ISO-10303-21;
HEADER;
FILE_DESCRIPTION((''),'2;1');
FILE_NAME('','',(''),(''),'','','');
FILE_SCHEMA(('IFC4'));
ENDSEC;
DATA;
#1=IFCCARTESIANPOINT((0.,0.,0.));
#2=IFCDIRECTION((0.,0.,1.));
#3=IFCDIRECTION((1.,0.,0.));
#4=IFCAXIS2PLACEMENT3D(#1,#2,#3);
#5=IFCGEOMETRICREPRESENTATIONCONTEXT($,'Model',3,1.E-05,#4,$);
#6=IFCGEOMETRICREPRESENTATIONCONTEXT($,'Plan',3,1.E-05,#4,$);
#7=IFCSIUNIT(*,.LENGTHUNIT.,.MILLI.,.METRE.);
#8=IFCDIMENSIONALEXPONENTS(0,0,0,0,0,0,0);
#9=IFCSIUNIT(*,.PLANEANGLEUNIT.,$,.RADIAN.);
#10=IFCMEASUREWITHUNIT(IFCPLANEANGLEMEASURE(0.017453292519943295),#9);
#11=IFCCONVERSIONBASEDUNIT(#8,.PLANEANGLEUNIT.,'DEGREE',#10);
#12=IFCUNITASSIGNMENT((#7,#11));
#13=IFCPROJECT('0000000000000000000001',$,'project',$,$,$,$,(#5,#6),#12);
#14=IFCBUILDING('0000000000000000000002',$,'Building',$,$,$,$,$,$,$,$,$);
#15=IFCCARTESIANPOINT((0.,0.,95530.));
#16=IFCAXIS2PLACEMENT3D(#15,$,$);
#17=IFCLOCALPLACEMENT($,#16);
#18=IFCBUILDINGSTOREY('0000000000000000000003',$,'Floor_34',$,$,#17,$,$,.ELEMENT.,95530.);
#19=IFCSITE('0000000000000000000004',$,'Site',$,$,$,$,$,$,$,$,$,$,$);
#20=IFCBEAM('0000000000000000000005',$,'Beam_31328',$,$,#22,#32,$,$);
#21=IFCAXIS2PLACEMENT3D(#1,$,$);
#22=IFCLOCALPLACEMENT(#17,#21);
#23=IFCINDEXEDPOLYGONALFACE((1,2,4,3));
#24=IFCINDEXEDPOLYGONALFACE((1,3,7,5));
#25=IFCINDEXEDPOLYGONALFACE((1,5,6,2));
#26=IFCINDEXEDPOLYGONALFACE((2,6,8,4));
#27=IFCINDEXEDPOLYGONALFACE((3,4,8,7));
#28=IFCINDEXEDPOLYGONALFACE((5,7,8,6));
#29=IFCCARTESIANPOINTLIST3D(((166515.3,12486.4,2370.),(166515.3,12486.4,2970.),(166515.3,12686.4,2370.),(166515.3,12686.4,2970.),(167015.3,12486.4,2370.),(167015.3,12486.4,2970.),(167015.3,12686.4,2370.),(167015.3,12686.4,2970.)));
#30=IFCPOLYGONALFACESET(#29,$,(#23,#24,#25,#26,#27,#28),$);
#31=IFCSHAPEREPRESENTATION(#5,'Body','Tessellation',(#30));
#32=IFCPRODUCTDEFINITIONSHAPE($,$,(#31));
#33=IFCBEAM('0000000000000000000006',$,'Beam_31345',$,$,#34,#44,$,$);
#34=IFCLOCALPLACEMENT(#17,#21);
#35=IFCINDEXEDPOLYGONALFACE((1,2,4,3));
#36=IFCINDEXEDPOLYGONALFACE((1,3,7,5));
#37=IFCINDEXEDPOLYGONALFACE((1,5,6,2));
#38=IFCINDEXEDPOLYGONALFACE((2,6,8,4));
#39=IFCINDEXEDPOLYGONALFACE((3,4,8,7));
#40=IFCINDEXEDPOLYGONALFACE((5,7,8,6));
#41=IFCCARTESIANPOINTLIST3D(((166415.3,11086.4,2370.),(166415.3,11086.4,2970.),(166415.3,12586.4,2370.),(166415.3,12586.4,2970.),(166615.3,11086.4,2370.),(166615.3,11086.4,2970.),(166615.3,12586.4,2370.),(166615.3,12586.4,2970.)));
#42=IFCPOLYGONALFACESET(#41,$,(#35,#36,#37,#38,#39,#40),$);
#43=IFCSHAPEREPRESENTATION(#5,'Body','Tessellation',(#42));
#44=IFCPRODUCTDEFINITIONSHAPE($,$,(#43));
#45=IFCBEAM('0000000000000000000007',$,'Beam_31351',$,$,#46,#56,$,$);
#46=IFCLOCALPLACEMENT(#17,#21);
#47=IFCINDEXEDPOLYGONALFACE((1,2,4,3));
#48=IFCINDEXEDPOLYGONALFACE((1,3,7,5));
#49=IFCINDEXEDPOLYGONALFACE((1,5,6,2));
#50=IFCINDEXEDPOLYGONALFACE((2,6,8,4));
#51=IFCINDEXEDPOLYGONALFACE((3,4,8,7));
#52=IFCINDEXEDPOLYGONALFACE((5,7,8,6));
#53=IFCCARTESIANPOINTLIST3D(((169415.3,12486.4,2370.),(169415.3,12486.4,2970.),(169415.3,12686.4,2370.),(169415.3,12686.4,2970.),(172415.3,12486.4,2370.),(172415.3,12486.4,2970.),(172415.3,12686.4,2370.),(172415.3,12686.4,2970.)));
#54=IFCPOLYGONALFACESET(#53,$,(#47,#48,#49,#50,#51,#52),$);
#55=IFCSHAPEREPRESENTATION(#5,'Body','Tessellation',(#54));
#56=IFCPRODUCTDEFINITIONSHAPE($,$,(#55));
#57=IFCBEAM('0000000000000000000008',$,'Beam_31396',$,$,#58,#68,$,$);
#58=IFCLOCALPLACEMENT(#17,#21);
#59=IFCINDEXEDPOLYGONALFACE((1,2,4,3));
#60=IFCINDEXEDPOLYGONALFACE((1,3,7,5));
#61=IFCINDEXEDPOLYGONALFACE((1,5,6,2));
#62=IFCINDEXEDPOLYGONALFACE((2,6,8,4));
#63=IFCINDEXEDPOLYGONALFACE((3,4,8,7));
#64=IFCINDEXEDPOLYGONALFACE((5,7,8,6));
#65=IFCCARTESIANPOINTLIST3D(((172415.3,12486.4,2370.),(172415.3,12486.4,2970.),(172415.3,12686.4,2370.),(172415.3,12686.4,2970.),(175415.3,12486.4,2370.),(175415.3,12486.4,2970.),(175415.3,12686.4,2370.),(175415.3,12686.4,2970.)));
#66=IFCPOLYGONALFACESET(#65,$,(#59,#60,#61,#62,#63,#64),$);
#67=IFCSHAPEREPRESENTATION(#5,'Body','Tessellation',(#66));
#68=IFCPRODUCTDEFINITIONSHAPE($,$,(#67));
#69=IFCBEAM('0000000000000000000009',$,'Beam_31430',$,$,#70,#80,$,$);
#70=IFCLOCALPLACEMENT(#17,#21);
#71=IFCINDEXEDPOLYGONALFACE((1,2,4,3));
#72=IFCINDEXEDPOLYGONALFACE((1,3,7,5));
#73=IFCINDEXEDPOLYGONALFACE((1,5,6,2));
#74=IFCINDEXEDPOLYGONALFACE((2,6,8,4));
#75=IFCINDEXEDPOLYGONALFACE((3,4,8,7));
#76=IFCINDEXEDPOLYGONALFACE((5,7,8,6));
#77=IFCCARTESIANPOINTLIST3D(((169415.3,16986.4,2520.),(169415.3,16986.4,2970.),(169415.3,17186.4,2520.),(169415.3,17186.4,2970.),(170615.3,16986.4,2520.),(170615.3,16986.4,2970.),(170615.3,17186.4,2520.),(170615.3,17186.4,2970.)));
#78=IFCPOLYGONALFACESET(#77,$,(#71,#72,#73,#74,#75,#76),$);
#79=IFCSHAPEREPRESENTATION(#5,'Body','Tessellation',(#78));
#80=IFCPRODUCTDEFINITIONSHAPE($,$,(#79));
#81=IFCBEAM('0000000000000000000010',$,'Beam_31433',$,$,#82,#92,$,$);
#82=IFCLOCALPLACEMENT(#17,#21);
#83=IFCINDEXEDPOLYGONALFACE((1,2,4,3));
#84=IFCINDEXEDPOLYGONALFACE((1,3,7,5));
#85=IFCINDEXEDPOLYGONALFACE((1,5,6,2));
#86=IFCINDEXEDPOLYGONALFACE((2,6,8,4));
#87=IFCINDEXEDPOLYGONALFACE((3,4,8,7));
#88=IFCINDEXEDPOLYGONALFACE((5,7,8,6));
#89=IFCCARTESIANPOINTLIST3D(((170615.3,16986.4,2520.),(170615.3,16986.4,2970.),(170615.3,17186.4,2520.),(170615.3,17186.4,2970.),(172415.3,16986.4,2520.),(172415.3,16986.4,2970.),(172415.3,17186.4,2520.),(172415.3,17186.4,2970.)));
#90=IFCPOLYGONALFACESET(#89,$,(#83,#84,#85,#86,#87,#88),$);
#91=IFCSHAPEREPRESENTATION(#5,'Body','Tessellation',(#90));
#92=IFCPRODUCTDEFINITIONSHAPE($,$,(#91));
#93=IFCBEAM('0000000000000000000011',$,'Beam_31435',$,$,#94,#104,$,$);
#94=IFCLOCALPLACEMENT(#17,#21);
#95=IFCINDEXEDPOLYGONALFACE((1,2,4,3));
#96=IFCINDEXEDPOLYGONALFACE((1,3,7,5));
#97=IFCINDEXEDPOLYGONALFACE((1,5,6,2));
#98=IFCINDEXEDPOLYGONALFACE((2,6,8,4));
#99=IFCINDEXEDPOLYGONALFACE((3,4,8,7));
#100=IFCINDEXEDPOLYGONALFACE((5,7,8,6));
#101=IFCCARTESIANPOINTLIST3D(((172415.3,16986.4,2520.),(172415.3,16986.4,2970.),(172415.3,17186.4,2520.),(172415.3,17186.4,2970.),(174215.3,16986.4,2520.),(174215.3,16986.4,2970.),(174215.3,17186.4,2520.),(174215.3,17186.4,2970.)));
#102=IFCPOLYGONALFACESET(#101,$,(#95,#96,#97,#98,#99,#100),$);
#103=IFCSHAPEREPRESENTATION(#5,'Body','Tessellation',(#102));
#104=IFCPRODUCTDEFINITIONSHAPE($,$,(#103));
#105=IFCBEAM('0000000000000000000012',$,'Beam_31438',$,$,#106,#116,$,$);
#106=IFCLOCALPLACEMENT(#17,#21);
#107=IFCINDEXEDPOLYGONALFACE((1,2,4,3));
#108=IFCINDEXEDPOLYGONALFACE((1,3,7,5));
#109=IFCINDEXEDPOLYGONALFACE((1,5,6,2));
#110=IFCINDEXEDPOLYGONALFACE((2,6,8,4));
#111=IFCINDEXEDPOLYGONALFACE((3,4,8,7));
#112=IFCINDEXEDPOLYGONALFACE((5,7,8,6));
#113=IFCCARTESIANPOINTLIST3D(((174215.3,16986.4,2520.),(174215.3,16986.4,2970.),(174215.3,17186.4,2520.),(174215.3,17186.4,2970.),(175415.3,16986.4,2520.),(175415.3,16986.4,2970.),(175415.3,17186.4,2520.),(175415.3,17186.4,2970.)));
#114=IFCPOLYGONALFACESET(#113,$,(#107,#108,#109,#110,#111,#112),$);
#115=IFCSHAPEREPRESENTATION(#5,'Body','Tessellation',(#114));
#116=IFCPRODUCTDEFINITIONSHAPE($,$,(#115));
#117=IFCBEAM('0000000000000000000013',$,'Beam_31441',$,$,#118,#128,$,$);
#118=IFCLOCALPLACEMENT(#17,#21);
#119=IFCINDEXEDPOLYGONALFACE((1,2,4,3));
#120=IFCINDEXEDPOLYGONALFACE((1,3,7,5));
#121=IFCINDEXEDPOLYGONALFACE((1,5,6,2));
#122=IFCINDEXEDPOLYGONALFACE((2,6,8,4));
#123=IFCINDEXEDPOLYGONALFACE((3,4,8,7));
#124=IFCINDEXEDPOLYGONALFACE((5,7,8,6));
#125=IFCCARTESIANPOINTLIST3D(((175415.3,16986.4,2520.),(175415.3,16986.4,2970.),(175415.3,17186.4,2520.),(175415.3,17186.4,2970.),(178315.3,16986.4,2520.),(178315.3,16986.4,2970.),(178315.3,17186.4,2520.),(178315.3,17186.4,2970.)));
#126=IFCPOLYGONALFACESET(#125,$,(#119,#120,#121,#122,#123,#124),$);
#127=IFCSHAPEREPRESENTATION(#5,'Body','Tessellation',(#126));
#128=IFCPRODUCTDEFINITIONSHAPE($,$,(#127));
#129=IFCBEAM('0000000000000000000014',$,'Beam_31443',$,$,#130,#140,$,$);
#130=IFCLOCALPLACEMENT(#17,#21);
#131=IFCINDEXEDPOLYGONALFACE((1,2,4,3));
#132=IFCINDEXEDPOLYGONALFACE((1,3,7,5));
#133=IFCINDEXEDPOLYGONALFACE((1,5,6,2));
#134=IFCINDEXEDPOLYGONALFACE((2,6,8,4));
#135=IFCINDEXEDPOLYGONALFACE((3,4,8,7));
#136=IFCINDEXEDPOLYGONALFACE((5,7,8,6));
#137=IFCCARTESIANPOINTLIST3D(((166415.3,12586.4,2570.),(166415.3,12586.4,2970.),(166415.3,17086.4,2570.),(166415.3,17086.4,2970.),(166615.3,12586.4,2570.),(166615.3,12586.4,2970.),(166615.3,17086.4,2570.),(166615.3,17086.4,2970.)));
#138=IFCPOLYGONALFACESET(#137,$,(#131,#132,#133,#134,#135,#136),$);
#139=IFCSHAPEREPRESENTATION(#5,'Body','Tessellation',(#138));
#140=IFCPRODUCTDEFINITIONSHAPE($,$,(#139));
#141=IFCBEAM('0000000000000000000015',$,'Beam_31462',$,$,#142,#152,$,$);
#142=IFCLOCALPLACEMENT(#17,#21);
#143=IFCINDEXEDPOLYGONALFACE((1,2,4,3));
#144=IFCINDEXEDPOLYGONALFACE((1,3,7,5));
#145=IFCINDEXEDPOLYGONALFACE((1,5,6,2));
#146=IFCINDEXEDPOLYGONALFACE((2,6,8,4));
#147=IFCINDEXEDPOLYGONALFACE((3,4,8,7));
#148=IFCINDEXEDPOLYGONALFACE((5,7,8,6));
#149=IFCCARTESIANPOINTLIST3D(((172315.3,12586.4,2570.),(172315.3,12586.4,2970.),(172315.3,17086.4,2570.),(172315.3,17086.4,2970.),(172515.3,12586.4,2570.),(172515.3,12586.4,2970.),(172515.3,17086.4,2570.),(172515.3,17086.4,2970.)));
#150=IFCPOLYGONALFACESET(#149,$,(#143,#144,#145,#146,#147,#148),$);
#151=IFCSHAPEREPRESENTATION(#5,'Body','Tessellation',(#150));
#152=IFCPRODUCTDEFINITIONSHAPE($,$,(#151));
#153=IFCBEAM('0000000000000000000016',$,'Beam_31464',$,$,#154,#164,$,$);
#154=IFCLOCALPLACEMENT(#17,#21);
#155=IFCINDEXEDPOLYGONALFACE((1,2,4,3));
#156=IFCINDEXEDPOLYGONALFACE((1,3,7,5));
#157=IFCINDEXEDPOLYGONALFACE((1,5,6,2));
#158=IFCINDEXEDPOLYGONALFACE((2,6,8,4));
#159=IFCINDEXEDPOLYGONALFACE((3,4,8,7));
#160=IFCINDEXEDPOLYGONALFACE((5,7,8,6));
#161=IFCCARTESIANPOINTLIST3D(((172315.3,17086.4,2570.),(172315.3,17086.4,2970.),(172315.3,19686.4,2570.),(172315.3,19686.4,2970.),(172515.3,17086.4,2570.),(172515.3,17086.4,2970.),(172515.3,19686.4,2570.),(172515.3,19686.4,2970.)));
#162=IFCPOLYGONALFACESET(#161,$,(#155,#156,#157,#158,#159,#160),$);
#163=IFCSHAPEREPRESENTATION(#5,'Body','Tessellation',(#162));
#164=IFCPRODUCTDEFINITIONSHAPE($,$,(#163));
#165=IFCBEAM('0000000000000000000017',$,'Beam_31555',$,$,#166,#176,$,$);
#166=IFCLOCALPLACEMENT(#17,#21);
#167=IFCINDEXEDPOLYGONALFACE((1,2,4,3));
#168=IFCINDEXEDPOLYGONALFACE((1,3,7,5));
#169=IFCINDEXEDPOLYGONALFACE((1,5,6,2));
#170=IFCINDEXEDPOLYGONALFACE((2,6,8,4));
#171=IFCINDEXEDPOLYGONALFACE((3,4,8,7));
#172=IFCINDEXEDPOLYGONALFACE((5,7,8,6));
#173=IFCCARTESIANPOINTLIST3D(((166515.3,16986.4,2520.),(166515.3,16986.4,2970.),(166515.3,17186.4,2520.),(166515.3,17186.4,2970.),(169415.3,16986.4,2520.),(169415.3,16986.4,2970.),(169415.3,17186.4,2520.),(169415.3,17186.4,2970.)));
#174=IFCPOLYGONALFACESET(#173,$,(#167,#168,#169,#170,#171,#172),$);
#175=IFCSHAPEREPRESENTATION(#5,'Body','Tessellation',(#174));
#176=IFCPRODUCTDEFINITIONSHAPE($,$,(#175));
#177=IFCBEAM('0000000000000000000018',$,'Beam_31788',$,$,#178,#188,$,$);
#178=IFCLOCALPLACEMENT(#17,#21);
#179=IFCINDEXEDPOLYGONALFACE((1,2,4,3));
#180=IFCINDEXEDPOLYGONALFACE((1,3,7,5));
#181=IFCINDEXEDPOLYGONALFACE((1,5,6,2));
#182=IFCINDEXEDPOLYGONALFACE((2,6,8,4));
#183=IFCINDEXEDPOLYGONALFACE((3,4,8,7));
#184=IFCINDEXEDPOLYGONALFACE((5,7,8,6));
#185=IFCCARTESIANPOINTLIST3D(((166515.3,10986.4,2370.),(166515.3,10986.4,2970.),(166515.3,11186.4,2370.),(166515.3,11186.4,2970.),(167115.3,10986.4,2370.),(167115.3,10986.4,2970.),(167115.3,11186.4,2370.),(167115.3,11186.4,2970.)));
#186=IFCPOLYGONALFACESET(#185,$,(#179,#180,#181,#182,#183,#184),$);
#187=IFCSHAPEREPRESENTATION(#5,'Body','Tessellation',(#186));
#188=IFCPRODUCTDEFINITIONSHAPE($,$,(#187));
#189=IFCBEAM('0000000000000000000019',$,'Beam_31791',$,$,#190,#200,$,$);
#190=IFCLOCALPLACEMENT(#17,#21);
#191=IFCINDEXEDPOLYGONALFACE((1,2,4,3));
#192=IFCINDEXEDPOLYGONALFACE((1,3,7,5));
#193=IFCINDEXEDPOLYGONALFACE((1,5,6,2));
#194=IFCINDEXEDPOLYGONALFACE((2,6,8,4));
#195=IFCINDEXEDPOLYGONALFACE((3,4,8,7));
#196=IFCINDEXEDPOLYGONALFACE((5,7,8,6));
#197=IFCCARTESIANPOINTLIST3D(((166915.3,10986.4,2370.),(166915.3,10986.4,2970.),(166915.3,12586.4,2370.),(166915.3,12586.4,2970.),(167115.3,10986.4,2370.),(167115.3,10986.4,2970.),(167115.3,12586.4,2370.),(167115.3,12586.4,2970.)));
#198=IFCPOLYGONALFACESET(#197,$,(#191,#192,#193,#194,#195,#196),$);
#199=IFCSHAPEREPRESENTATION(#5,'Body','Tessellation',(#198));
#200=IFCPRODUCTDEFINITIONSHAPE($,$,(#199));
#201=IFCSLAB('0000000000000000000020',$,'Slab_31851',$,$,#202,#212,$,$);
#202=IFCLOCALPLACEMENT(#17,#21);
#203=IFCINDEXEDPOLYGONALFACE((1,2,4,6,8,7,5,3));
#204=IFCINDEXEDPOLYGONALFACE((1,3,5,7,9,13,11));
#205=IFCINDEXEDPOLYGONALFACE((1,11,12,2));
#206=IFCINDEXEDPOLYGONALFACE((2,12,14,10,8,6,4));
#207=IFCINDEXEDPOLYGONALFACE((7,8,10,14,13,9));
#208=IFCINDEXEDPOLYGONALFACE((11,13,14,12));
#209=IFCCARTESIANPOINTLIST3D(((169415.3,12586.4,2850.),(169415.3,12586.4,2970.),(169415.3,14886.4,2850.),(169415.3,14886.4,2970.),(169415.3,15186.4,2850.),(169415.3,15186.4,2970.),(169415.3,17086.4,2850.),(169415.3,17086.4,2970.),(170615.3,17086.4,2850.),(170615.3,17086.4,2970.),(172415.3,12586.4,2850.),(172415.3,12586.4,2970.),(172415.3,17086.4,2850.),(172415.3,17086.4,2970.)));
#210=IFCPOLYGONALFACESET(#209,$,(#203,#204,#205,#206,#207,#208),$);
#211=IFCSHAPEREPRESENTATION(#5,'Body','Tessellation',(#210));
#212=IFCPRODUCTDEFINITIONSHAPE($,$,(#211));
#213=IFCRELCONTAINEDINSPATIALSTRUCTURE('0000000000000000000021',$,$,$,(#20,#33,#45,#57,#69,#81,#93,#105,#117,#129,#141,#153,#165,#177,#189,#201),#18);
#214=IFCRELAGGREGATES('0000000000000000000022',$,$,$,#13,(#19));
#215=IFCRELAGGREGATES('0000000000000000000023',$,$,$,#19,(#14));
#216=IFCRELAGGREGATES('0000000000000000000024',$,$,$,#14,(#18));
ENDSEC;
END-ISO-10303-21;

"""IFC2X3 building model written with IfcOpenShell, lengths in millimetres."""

from ifc_helpers import new_model, entity, si_unit, converted_unit, frame, origin_with_axes, origin_2d, place, context, project, spatial, polyline, rectangle, outline, extrude, element, save


model = new_model("IFC2X3")

# Units and contexts
model_context = context("Model", 3, precision=1e-05, world=origin_with_axes())
plan_context = context("Plan", 3, precision=1e-05, world=origin_with_axes())
ifc_project = project(units=[si_unit("LENGTHUNIT", "METRE", prefix="MILLI"), converted_unit("PLANEANGLEUNIT", "DEGREE", entity("IfcPlaneAngleMeasure", 0.017453292519943295), si_unit("PLANEANGLEUNIT", "RADIAN"), dimensions=[0, 0, 0, 0, 0, 0, 0])], contexts=[model_context, plan_context])

# Site, building, storey
site = spatial("IfcSite", under=ifc_project, Name="Site")
building = spatial("IfcBuilding", under=site, Name="Building")
storey_placement = place(None, frame((0.0, 0.0, 95530.0)))
storey = spatial("IfcBuildingStorey", under=building, at=storey_placement, Name="Floor_34", CompositionType="ELEMENT", Elevation=95530.0)

# Beams
beam_1_placement = place(storey_placement, frame((166515.3, 12586.4, 2670.0), z_axis=(500.0, 0.0, 0.0), x_axis=(0.0, -500.0, 0.0)))
element("IfcBeam", 1, at=beam_1_placement, inside=storey, Name="Beam_31328", context=model_context, shape_type="SweptSolid", body=[
    extrude(rectangle(XDim=200.0, YDim=600.0, at=origin_2d()), origin_with_axes(), (0.0, 0.0, 1.0), 500.0),
])
beam_2_placement = place(storey_placement, frame((166515.3, 11086.4, 2670.0), z_axis=(0.0, 1500.0, 0.0), x_axis=(1500.0, 0.0, 0.0)))
element("IfcBeam", 2, at=beam_2_placement, inside=storey, Name="Beam_31345", context=model_context, shape_type="SweptSolid", body=[
    extrude(rectangle(XDim=200.0, YDim=600.0, at=origin_2d()), origin_with_axes(), (0.0, 0.0, 1.0), 1500.0),
])
for number, where, z_axis, x_axis, name in (
    (3, (169415.3, 12586.4, 2670.0), (2999.999693, 0.0, 0.0), (0.0, -2999.999693, 0.0), "Beam_31351"),
    (4, (172415.3, 12586.4, 2670.0), (2999.999693, 0.0, 0.0), (0.0, -2999.999693, 0.0), "Beam_31396"),
):
    element("IfcBeam", number, at=place(storey_placement, frame(where, z_axis=z_axis, x_axis=x_axis)), inside=storey, Name=name, context=model_context, shape_type="SweptSolid", body=[
        extrude(rectangle(XDim=200.0, YDim=600.0, at=origin_2d()), origin_with_axes(), (0.0, 0.0, 1.0), 3000.0),
    ])
beam_3_placement = place(storey_placement, frame((169415.3, 17086.4, 2745.0), z_axis=(1199.99968, -0.000012, 0.0), x_axis=(-0.000012, -1199.99968, 0.0)))
element("IfcBeam", 5, at=beam_3_placement, inside=storey, Name="Beam_31430", context=model_context, shape_type="SweptSolid", body=[
    extrude(rectangle(XDim=200.0, YDim=450.0, at=origin_2d()), origin_with_axes(), (0.0, 0.0, 1.0), 1200.0),
])
for number, where, z_axis, x_axis, name in (
    (6, (170615.3, 17086.4, 2745.0), (1800.000018, 0.000024, 0.0), (0.000024, -1800.000018, 0.0), "Beam_31433"),
    (7, (172415.3, 17086.4, 2745.0), (1800.000018, -0.000024, 0.0), (-0.000024, -1800.000018, 0.0), "Beam_31435"),
):
    element("IfcBeam", number, at=place(storey_placement, frame(where, z_axis=z_axis, x_axis=x_axis)), inside=storey, Name=name, context=model_context, shape_type="SweptSolid", body=[
        extrude(rectangle(XDim=200.0, YDim=450.0, at=origin_2d()), origin_with_axes(), (0.0, 0.0, 1.0), 1800.0),
    ])
beam_4_placement = place(storey_placement, frame((174215.3, 17086.4, 2745.0), z_axis=(1199.999669, 0.000037, 0.0), x_axis=(0.000037, -1199.999669, 0.0)))
element("IfcBeam", 8, at=beam_4_placement, inside=storey, Name="Beam_31438", context=model_context, shape_type="SweptSolid", body=[
    extrude(rectangle(XDim=200.0, YDim=450.0, at=origin_2d()), origin_with_axes(), (0.0, 0.0, 1.0), 1200.0),
])
beam_5_placement = place(storey_placement, frame((175415.3, 17086.4, 2745.0), z_axis=(2899.999861, 0.000012, 0.0), x_axis=(0.000012, -2899.999861, 0.0)))
element("IfcBeam", 9, at=beam_5_placement, inside=storey, Name="Beam_31441", context=model_context, shape_type="SweptSolid", body=[
    extrude(rectangle(XDim=200.0, YDim=450.0, at=origin_2d()), origin_with_axes(), (0.0, 0.0, 1.0), 2900.0),
])
beam_6_placement = place(storey_placement, frame((166515.3, 12586.4, 2770.0), z_axis=(-0.00001, 4500.03064, 0.0), x_axis=(4500.03064, 0.00001, 0.0)))
element("IfcBeam", 10, at=beam_6_placement, inside=storey, Name="Beam_31443", context=model_context, shape_type="SweptSolid", body=[
    extrude(rectangle(XDim=200.0, YDim=400.0, at=origin_2d()), origin_with_axes(), (0.0, 0.0, 1.0), 4500.0),
])
beam_7_placement = place(storey_placement, frame((172415.3, 12586.4, 2770.0), z_axis=(0.0, 4500.030665, 0.0), x_axis=(4500.030665, 0.0, 0.0)))
element("IfcBeam", 11, at=beam_7_placement, inside=storey, Name="Beam_31462", context=model_context, shape_type="SweptSolid", body=[
    extrude(rectangle(XDim=200.0, YDim=400.0, at=origin_2d()), origin_with_axes(), (0.0, 0.0, 1.0), 4500.0),
])
beam_8_placement = place(storey_placement, frame((172415.3, 17086.4, 2770.0), z_axis=(0.0, 2599.990188, 0.0), x_axis=(2599.990188, 0.0, 0.0)))
element("IfcBeam", 12, at=beam_8_placement, inside=storey, Name="Beam_31464", context=model_context, shape_type="SweptSolid", body=[
    extrude(rectangle(XDim=200.0, YDim=400.0, at=origin_2d()), origin_with_axes(), (0.0, 0.0, 1.0), 2600.0),
])
beam_9_placement = place(storey_placement, frame((166515.3, 17086.4, 2745.0), z_axis=(2900.000194, 0.000012, 0.0), x_axis=(0.000012, -2900.000194, 0.0)))
element("IfcBeam", 13, at=beam_9_placement, inside=storey, Name="Beam_31555", context=model_context, shape_type="SweptSolid", body=[
    extrude(rectangle(XDim=200.0, YDim=450.0, at=origin_2d()), origin_with_axes(), (0.0, 0.0, 1.0), 2900.0),
])
beam_10_placement = place(storey_placement, frame((166515.3, 11086.4, 2670.0), z_axis=(600.0, 0.0, 0.0), x_axis=(0.0, -600.0, 0.0)))
element("IfcBeam", 14, at=beam_10_placement, inside=storey, Name="Beam_31788", context=model_context, shape_type="SweptSolid", body=[
    extrude(rectangle(XDim=200.0, YDim=600.0, at=origin_2d()), origin_with_axes(), (0.0, 0.0, 1.0), 600.0),
])
beam_11_placement = place(storey_placement, frame((167015.3, 10986.4, 2670.0), z_axis=(0.0, 1600.0, 0.0), x_axis=(1600.0, 0.0, 0.0)))
element("IfcBeam", 15, at=beam_11_placement, inside=storey, Name="Beam_31791", context=model_context, shape_type="SweptSolid", body=[
    extrude(rectangle(XDim=200.0, YDim=600.0, at=origin_2d()), origin_with_axes(), (0.0, 0.0, 1.0), 1600.0),
])

# Slab
slab_1_placement = place(storey_placement, frame((169415.3, 17086.4, 2850.0), z_axis=(0.0, 0.0, 1.0), x_axis=(-0.006, -1900.025, 0.0)))
element("IfcSlab", 16, at=slab_1_placement, inside=storey, Name="Slab_31851", context=model_context, shape_type="SweptSolid", body=[
    extrude(outline(polyline([(0.0, 0.0), (1900.0, 0.0), (2200.0, 0.0), (4500.0, 0.0), (4500.0, 3000.0), (0.0, 3000.0), (0.0, 1200.0)])), origin_with_axes(), (0.0, 0.0, 1.0), 120.0),
])

save(model, "model.ifc")
